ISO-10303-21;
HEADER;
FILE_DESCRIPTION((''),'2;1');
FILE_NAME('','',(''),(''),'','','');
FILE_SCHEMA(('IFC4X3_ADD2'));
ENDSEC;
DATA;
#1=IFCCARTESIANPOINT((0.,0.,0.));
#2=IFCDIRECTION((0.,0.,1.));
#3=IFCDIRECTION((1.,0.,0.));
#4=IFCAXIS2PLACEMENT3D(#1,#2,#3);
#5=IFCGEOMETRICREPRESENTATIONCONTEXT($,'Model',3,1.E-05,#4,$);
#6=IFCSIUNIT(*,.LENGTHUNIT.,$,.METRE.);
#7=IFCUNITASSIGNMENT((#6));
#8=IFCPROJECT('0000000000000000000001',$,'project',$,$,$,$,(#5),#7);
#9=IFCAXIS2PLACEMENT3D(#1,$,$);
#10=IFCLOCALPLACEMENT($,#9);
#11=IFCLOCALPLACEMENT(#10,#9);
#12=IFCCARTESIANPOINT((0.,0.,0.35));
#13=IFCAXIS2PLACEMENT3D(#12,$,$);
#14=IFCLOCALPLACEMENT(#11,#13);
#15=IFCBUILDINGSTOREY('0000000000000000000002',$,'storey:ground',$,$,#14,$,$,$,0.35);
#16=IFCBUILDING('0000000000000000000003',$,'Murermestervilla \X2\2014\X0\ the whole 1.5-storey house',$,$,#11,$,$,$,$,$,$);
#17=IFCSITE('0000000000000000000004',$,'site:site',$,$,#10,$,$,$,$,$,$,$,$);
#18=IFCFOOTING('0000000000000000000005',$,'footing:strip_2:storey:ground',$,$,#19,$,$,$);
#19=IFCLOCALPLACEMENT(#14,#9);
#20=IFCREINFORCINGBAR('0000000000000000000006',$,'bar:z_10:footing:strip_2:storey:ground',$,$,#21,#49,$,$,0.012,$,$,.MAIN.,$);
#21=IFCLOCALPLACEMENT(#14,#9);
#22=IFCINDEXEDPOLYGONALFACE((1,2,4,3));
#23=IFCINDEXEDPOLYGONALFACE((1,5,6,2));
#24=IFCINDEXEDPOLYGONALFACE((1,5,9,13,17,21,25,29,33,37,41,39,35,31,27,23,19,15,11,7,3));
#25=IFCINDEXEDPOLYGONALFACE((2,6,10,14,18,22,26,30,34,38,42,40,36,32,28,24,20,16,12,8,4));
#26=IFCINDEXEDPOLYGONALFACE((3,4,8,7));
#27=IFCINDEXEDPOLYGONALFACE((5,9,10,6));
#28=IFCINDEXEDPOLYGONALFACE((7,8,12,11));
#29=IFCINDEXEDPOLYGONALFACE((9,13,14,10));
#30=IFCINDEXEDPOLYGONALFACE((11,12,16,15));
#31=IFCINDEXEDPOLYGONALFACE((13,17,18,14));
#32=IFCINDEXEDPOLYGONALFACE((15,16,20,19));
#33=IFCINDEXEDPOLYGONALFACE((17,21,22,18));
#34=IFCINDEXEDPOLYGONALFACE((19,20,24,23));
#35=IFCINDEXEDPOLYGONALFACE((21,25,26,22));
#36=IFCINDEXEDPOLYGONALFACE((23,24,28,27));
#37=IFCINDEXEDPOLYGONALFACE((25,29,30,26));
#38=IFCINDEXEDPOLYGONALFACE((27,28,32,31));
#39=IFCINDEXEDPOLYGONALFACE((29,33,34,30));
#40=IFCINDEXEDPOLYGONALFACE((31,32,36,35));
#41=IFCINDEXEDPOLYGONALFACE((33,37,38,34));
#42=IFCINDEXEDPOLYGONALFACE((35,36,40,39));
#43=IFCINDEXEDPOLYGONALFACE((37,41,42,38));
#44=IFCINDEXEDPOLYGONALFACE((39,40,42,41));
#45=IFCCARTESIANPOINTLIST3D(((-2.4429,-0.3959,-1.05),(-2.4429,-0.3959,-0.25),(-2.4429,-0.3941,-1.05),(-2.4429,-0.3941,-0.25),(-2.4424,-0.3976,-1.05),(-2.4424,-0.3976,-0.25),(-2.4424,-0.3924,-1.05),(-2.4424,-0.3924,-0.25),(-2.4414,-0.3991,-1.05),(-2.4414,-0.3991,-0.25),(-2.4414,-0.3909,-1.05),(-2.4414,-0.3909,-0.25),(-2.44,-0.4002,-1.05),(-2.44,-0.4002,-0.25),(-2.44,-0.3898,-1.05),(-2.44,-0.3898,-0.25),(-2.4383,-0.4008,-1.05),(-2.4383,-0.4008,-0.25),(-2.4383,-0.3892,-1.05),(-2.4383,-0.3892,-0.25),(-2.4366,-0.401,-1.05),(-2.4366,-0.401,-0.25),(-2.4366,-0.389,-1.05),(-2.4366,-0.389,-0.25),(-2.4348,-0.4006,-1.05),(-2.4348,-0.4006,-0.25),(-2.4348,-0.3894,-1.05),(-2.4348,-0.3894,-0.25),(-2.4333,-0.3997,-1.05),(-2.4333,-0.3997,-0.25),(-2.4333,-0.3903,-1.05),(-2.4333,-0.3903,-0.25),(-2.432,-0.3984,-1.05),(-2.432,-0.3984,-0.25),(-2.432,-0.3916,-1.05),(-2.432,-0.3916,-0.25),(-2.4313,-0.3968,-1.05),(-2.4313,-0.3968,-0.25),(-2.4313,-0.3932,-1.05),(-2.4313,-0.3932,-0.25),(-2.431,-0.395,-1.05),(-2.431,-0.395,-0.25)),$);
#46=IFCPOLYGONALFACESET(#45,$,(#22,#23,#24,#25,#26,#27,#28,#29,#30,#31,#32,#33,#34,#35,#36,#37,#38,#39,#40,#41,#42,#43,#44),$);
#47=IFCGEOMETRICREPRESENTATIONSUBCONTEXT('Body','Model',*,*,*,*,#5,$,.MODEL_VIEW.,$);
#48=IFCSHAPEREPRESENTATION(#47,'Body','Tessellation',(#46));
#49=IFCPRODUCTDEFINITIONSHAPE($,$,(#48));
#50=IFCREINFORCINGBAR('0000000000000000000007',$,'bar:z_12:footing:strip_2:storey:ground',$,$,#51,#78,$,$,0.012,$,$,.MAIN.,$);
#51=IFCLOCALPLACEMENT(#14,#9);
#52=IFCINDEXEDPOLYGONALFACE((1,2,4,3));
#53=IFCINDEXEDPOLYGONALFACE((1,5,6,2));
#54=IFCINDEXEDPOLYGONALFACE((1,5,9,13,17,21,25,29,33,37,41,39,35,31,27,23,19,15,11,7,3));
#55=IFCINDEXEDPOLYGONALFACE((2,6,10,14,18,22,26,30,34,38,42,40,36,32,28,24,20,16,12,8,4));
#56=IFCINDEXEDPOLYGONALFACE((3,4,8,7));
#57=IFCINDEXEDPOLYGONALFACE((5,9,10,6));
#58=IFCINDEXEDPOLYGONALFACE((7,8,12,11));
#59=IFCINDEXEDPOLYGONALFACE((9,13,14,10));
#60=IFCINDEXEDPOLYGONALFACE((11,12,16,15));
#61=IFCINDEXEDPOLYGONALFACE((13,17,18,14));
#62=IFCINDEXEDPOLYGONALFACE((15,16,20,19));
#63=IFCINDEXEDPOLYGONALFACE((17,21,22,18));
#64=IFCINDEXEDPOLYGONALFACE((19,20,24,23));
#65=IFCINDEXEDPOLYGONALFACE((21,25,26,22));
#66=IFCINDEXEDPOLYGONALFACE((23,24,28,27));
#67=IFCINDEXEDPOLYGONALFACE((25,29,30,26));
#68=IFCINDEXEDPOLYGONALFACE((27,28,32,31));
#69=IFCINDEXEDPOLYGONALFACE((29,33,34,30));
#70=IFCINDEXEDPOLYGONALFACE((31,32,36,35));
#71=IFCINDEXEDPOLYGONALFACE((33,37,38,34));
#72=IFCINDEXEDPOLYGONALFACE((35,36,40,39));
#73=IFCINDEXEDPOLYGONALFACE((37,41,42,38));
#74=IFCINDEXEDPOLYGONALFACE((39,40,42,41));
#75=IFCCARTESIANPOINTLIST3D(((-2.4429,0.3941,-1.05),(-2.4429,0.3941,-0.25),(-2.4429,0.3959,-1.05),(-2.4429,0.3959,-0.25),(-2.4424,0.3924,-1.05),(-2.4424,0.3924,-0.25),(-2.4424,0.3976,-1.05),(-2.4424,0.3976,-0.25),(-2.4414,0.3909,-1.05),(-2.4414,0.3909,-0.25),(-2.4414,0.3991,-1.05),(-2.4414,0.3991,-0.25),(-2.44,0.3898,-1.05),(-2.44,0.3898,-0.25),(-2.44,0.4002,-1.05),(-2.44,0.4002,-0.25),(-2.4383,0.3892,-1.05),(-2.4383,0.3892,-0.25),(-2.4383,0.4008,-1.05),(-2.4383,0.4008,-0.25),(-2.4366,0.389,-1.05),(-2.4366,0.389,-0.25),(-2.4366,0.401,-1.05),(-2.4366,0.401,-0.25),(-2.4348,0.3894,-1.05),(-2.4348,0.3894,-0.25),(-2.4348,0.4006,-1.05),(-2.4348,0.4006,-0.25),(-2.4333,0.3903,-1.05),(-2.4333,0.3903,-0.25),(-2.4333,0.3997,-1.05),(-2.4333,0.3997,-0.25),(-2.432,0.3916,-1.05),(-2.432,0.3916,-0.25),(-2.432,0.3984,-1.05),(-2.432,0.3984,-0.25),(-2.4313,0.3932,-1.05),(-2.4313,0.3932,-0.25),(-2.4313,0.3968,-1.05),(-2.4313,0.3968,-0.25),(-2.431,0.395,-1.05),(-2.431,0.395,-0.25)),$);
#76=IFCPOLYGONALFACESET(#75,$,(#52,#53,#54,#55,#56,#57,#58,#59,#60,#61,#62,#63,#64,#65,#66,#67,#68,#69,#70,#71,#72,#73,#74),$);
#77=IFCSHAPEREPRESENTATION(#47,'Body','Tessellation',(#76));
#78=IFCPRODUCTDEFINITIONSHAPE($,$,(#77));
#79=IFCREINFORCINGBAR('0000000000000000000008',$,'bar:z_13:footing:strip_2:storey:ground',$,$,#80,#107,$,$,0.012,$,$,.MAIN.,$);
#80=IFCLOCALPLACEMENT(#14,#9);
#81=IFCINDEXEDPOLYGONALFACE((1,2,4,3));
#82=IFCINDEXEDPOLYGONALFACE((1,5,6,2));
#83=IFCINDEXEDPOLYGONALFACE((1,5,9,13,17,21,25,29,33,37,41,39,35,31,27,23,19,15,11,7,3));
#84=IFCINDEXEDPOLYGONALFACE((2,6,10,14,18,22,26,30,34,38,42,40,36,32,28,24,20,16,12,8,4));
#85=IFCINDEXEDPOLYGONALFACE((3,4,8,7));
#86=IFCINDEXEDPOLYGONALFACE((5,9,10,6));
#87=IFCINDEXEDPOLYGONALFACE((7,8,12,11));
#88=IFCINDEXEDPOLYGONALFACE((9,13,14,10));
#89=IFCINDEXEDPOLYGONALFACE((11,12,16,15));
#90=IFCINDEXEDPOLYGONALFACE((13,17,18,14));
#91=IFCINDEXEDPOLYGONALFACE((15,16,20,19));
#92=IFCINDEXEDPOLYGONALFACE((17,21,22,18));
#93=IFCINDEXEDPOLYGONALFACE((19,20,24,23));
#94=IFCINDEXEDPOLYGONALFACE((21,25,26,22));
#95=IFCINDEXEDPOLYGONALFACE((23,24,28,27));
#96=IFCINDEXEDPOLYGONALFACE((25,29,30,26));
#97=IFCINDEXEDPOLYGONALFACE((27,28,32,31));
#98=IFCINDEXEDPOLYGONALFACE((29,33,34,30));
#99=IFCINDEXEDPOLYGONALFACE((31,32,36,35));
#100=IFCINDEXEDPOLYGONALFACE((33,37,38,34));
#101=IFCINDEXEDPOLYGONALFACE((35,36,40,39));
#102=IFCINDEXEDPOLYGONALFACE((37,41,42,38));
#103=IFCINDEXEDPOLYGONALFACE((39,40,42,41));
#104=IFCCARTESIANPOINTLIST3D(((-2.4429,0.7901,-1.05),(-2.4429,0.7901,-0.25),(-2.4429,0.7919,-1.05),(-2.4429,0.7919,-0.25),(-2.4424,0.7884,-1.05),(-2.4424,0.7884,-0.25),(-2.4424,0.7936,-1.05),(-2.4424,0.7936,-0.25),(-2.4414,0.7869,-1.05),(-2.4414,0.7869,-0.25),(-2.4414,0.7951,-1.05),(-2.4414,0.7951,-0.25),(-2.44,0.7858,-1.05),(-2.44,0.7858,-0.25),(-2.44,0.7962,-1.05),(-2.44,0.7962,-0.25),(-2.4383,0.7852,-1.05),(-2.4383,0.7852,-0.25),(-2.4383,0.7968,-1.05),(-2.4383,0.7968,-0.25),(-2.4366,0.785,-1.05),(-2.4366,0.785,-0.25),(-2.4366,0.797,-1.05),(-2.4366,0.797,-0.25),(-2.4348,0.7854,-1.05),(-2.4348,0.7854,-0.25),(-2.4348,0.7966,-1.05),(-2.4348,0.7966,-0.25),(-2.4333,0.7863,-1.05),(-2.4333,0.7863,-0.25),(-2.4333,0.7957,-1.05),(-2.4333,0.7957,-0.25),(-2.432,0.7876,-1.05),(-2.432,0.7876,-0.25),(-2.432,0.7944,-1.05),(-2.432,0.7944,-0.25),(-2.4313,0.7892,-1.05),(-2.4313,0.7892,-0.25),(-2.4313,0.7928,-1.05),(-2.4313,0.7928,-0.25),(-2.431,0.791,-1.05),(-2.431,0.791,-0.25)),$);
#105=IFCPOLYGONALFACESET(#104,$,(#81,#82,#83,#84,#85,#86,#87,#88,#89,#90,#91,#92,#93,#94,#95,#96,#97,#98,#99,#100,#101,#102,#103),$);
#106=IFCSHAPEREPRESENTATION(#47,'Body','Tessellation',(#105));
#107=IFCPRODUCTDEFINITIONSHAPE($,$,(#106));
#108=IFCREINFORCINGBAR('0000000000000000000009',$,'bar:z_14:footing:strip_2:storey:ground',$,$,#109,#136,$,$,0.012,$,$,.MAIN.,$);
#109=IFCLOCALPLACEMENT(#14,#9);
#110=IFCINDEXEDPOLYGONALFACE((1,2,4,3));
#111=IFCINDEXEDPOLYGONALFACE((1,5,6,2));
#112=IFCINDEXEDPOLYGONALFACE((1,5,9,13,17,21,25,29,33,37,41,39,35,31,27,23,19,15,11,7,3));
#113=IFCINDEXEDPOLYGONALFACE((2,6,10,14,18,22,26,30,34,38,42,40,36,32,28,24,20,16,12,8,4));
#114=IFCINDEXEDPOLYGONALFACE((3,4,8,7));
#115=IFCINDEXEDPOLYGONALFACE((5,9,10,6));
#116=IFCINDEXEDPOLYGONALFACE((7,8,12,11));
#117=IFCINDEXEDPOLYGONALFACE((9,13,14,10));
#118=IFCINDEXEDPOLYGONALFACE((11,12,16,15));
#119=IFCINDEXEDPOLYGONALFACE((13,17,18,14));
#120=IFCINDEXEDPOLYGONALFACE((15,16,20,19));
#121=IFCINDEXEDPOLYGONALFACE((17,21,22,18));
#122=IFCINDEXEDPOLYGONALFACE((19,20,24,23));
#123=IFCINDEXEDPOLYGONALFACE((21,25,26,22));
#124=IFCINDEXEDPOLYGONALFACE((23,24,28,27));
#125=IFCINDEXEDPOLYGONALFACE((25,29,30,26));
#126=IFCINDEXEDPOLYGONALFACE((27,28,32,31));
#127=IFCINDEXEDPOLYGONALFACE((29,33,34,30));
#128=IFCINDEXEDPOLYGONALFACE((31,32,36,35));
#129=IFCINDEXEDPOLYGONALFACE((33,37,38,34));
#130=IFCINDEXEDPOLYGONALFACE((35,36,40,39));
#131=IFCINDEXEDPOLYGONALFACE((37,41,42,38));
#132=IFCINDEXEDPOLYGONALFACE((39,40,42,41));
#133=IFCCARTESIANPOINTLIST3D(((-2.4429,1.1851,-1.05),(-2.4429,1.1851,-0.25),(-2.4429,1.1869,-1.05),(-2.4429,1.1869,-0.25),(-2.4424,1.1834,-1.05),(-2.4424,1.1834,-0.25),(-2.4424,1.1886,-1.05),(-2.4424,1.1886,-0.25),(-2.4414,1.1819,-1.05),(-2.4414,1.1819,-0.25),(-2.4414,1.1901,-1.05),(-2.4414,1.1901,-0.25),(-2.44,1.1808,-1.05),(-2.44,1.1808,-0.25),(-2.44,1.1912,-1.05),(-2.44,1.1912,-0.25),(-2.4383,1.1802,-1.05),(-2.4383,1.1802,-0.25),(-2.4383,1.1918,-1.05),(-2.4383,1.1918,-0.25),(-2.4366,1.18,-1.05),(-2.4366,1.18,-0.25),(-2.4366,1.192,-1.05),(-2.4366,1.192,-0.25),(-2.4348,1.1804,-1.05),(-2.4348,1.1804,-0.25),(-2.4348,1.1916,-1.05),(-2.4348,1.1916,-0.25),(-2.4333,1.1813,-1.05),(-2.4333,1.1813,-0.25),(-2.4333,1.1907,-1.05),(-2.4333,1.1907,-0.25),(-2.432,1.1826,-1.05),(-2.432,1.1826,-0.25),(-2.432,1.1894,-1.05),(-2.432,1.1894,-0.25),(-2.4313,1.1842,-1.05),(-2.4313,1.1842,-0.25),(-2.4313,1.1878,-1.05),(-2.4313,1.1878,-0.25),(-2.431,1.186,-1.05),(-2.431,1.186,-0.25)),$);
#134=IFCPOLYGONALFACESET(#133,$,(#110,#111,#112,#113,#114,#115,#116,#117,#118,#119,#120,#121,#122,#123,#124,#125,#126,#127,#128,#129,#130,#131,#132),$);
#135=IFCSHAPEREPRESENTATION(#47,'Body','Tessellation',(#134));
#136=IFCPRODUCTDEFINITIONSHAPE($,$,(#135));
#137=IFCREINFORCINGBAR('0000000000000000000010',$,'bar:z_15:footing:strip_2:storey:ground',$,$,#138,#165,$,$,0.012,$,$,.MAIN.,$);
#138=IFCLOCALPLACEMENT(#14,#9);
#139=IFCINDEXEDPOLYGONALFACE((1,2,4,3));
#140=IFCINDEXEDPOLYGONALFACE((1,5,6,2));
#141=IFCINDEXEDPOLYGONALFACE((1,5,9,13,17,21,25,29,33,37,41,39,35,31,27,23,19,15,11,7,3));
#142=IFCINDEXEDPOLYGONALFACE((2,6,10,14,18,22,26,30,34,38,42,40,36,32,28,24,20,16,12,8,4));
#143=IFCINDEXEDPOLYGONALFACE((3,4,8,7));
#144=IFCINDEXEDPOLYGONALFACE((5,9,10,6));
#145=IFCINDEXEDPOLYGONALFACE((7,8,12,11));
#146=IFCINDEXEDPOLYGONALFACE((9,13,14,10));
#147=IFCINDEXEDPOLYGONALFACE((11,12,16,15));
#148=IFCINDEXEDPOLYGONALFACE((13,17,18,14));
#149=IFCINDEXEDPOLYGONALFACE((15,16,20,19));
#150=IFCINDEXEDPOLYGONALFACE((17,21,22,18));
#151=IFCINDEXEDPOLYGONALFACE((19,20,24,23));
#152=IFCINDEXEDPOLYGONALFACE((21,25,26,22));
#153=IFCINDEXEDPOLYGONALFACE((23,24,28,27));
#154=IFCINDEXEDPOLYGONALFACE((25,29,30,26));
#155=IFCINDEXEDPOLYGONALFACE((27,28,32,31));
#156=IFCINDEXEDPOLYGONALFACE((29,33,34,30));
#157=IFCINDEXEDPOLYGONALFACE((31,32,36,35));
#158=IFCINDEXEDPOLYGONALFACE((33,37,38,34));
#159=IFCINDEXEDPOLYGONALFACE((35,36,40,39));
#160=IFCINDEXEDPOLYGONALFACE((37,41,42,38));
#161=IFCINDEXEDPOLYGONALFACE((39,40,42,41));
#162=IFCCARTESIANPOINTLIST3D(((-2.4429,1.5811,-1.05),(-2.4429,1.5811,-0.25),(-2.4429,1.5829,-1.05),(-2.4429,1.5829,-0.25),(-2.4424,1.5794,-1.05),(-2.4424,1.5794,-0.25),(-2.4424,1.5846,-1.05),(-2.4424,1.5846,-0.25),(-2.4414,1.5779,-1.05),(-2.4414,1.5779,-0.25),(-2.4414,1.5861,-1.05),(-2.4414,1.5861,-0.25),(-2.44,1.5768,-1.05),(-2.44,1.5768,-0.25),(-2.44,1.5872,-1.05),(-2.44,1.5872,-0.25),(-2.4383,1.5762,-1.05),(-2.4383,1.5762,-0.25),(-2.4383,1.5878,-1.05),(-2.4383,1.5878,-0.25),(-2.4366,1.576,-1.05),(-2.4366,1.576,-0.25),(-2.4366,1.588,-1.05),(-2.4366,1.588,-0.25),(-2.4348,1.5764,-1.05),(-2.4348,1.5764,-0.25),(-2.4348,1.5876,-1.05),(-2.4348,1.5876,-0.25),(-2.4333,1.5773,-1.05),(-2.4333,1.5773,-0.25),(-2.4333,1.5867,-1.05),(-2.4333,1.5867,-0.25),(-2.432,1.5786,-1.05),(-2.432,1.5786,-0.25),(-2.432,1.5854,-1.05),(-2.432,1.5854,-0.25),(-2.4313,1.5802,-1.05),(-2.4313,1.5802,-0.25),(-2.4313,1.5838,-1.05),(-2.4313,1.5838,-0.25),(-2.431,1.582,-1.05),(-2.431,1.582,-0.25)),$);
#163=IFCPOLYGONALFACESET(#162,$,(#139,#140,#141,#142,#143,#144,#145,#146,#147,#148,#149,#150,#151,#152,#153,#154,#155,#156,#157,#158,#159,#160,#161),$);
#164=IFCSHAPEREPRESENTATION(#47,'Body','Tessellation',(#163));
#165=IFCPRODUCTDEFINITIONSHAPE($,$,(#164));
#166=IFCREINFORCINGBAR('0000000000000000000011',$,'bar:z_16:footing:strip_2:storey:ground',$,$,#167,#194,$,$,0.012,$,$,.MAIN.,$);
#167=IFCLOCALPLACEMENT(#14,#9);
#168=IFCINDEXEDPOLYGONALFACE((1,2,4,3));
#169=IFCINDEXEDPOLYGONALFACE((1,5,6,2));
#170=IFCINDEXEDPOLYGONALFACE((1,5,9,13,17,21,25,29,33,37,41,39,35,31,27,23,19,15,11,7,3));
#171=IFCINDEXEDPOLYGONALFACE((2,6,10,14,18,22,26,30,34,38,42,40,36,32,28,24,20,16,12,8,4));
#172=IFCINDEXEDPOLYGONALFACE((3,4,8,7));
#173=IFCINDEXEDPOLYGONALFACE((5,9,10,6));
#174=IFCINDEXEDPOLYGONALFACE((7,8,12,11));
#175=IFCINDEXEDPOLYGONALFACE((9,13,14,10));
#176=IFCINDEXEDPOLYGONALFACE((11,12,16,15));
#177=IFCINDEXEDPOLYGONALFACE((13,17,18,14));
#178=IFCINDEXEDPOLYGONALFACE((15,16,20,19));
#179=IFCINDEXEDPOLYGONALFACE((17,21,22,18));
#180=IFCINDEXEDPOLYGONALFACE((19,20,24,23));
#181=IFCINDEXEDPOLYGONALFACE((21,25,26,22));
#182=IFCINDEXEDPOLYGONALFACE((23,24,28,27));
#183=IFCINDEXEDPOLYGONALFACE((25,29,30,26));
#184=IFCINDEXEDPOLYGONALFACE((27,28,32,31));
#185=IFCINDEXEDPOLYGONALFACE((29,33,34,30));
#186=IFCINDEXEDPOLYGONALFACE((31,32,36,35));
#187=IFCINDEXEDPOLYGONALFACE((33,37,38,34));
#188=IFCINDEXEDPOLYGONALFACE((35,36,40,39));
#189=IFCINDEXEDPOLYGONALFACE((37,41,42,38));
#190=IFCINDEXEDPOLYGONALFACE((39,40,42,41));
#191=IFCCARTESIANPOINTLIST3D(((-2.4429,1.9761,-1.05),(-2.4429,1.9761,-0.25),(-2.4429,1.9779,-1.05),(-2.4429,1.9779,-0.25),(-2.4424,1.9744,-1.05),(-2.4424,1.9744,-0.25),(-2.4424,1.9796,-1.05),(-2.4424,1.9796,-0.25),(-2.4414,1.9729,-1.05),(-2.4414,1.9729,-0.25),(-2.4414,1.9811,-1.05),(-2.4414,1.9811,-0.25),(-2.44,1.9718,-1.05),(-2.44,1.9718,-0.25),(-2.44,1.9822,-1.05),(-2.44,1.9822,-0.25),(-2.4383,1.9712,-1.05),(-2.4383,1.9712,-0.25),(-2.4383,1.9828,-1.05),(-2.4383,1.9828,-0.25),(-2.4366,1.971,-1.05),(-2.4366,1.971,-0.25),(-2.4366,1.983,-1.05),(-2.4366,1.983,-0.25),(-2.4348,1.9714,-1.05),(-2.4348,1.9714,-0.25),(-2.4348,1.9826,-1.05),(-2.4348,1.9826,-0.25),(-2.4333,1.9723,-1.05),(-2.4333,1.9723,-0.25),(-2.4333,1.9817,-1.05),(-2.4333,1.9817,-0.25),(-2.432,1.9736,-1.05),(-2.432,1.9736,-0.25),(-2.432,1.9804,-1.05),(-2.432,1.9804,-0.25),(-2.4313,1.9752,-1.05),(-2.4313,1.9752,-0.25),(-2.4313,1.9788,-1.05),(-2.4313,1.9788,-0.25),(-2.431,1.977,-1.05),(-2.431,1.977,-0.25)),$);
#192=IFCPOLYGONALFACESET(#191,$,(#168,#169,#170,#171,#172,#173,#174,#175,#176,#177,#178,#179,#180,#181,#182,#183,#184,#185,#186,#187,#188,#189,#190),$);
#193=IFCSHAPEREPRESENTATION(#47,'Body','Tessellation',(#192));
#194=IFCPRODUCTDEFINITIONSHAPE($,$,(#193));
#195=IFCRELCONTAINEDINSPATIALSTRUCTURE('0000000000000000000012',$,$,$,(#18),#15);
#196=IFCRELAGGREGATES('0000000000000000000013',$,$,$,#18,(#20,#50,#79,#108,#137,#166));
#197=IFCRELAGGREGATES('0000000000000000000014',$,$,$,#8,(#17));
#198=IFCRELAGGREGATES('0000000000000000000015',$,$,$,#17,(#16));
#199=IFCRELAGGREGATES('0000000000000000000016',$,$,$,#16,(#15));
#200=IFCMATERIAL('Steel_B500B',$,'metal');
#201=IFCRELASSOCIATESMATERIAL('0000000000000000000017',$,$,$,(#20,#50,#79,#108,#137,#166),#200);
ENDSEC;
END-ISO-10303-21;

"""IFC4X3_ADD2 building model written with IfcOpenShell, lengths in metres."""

from ifc_helpers import new_model, entity, si_unit, frame, origin, origin_with_axes, place, context, subcontext, project, spatial, material, element, aggregate, save


model = new_model("IFC4X3_ADD2")

# Units and contexts
model_context = context("Model", 3, precision=1e-05, world=origin_with_axes())
body_context = subcontext(model_context, "Body", "Model", "MODEL_VIEW")
ifc_project = project(units=[si_unit("LENGTHUNIT", "METRE")], contexts=[model_context])

# Site, building, storey
placement_1 = place(None, origin())
site = spatial("IfcSite", under=ifc_project, at=placement_1, Name="site:site")
building_placement = place(placement_1, origin())
building = spatial("IfcBuilding", under=site, at=building_placement, Name="Murermestervilla — the whole 1.5-storey house")
storey_placement = place(building_placement, frame((0.0, 0.0, 0.35)))
storey = spatial("IfcBuildingStorey", under=building, at=storey_placement, Name="storey:ground", Elevation=0.35)

# Footing, reinforcing bars
placement_2 = place(storey_placement, frame((0.0, 0.0, -0.35)))
footing_1 = element("IfcFooting", 1, at=placement_2, inside=storey, Name="footing:strip_2:storey:ground")
ifc_material = material(Name="Steel_B500B", Category="metal")
reinforcing_bar_1 = element("IfcReinforcingBar", 2, at=placement_1, material=ifc_material, Name="bar:z_10:footing:strip_2:storey:ground", NominalDiameter=0.012, PredefinedType="MAIN", context=body_context, shape_type="AdvancedSweptSolid", body=[
    entity("IfcSweptDiskSolid", entity("IfcPolyline", [entity("IfcCartesianPoint", [-2.437, -0.395, -0.7]), entity("IfcCartesianPoint", [-2.437, -0.395, 0.1])]), 0.006),
])
reinforcing_bar_2 = element("IfcReinforcingBar", 3, at=placement_1, material=ifc_material, Name="bar:z_12:footing:strip_2:storey:ground", NominalDiameter=0.012, PredefinedType="MAIN", context=body_context, shape_type="AdvancedSweptSolid", body=[
    entity("IfcSweptDiskSolid", entity("IfcPolyline", [entity("IfcCartesianPoint", [-2.437, 0.395, -0.7]), entity("IfcCartesianPoint", [-2.437, 0.395, 0.1])]), 0.006),
])
reinforcing_bar_3 = element("IfcReinforcingBar", 4, at=placement_1, material=ifc_material, Name="bar:z_13:footing:strip_2:storey:ground", NominalDiameter=0.012, PredefinedType="MAIN", context=body_context, shape_type="AdvancedSweptSolid", body=[
    entity("IfcSweptDiskSolid", entity("IfcPolyline", [entity("IfcCartesianPoint", [-2.437, 0.791, -0.7]), entity("IfcCartesianPoint", [-2.437, 0.791, 0.1])]), 0.006),
])
reinforcing_bar_4 = element("IfcReinforcingBar", 5, at=placement_1, material=ifc_material, Name="bar:z_14:footing:strip_2:storey:ground", NominalDiameter=0.012, PredefinedType="MAIN", context=body_context, shape_type="AdvancedSweptSolid", body=[
    entity("IfcSweptDiskSolid", entity("IfcPolyline", [entity("IfcCartesianPoint", [-2.437, 1.186, -0.7]), entity("IfcCartesianPoint", [-2.437, 1.186, 0.1])]), 0.006),
])
reinforcing_bar_5 = element("IfcReinforcingBar", 6, at=placement_1, material=ifc_material, Name="bar:z_15:footing:strip_2:storey:ground", NominalDiameter=0.012, PredefinedType="MAIN", context=body_context, shape_type="AdvancedSweptSolid", body=[
    entity("IfcSweptDiskSolid", entity("IfcPolyline", [entity("IfcCartesianPoint", [-2.437, 1.582, -0.7]), entity("IfcCartesianPoint", [-2.437, 1.582, 0.1])]), 0.006),
])
reinforcing_bar_6 = element("IfcReinforcingBar", 7, at=placement_1, material=ifc_material, Name="bar:z_16:footing:strip_2:storey:ground", NominalDiameter=0.012, PredefinedType="MAIN", context=body_context, shape_type="AdvancedSweptSolid", body=[
    entity("IfcSweptDiskSolid", entity("IfcPolyline", [entity("IfcCartesianPoint", [-2.437, 1.977, -0.7]), entity("IfcCartesianPoint", [-2.437, 1.977, 0.1])]), 0.006),
])
aggregate(footing_1, [reinforcing_bar_1, reinforcing_bar_2, reinforcing_bar_3, reinforcing_bar_4, reinforcing_bar_5, reinforcing_bar_6])

save(model, "model.ifc")
